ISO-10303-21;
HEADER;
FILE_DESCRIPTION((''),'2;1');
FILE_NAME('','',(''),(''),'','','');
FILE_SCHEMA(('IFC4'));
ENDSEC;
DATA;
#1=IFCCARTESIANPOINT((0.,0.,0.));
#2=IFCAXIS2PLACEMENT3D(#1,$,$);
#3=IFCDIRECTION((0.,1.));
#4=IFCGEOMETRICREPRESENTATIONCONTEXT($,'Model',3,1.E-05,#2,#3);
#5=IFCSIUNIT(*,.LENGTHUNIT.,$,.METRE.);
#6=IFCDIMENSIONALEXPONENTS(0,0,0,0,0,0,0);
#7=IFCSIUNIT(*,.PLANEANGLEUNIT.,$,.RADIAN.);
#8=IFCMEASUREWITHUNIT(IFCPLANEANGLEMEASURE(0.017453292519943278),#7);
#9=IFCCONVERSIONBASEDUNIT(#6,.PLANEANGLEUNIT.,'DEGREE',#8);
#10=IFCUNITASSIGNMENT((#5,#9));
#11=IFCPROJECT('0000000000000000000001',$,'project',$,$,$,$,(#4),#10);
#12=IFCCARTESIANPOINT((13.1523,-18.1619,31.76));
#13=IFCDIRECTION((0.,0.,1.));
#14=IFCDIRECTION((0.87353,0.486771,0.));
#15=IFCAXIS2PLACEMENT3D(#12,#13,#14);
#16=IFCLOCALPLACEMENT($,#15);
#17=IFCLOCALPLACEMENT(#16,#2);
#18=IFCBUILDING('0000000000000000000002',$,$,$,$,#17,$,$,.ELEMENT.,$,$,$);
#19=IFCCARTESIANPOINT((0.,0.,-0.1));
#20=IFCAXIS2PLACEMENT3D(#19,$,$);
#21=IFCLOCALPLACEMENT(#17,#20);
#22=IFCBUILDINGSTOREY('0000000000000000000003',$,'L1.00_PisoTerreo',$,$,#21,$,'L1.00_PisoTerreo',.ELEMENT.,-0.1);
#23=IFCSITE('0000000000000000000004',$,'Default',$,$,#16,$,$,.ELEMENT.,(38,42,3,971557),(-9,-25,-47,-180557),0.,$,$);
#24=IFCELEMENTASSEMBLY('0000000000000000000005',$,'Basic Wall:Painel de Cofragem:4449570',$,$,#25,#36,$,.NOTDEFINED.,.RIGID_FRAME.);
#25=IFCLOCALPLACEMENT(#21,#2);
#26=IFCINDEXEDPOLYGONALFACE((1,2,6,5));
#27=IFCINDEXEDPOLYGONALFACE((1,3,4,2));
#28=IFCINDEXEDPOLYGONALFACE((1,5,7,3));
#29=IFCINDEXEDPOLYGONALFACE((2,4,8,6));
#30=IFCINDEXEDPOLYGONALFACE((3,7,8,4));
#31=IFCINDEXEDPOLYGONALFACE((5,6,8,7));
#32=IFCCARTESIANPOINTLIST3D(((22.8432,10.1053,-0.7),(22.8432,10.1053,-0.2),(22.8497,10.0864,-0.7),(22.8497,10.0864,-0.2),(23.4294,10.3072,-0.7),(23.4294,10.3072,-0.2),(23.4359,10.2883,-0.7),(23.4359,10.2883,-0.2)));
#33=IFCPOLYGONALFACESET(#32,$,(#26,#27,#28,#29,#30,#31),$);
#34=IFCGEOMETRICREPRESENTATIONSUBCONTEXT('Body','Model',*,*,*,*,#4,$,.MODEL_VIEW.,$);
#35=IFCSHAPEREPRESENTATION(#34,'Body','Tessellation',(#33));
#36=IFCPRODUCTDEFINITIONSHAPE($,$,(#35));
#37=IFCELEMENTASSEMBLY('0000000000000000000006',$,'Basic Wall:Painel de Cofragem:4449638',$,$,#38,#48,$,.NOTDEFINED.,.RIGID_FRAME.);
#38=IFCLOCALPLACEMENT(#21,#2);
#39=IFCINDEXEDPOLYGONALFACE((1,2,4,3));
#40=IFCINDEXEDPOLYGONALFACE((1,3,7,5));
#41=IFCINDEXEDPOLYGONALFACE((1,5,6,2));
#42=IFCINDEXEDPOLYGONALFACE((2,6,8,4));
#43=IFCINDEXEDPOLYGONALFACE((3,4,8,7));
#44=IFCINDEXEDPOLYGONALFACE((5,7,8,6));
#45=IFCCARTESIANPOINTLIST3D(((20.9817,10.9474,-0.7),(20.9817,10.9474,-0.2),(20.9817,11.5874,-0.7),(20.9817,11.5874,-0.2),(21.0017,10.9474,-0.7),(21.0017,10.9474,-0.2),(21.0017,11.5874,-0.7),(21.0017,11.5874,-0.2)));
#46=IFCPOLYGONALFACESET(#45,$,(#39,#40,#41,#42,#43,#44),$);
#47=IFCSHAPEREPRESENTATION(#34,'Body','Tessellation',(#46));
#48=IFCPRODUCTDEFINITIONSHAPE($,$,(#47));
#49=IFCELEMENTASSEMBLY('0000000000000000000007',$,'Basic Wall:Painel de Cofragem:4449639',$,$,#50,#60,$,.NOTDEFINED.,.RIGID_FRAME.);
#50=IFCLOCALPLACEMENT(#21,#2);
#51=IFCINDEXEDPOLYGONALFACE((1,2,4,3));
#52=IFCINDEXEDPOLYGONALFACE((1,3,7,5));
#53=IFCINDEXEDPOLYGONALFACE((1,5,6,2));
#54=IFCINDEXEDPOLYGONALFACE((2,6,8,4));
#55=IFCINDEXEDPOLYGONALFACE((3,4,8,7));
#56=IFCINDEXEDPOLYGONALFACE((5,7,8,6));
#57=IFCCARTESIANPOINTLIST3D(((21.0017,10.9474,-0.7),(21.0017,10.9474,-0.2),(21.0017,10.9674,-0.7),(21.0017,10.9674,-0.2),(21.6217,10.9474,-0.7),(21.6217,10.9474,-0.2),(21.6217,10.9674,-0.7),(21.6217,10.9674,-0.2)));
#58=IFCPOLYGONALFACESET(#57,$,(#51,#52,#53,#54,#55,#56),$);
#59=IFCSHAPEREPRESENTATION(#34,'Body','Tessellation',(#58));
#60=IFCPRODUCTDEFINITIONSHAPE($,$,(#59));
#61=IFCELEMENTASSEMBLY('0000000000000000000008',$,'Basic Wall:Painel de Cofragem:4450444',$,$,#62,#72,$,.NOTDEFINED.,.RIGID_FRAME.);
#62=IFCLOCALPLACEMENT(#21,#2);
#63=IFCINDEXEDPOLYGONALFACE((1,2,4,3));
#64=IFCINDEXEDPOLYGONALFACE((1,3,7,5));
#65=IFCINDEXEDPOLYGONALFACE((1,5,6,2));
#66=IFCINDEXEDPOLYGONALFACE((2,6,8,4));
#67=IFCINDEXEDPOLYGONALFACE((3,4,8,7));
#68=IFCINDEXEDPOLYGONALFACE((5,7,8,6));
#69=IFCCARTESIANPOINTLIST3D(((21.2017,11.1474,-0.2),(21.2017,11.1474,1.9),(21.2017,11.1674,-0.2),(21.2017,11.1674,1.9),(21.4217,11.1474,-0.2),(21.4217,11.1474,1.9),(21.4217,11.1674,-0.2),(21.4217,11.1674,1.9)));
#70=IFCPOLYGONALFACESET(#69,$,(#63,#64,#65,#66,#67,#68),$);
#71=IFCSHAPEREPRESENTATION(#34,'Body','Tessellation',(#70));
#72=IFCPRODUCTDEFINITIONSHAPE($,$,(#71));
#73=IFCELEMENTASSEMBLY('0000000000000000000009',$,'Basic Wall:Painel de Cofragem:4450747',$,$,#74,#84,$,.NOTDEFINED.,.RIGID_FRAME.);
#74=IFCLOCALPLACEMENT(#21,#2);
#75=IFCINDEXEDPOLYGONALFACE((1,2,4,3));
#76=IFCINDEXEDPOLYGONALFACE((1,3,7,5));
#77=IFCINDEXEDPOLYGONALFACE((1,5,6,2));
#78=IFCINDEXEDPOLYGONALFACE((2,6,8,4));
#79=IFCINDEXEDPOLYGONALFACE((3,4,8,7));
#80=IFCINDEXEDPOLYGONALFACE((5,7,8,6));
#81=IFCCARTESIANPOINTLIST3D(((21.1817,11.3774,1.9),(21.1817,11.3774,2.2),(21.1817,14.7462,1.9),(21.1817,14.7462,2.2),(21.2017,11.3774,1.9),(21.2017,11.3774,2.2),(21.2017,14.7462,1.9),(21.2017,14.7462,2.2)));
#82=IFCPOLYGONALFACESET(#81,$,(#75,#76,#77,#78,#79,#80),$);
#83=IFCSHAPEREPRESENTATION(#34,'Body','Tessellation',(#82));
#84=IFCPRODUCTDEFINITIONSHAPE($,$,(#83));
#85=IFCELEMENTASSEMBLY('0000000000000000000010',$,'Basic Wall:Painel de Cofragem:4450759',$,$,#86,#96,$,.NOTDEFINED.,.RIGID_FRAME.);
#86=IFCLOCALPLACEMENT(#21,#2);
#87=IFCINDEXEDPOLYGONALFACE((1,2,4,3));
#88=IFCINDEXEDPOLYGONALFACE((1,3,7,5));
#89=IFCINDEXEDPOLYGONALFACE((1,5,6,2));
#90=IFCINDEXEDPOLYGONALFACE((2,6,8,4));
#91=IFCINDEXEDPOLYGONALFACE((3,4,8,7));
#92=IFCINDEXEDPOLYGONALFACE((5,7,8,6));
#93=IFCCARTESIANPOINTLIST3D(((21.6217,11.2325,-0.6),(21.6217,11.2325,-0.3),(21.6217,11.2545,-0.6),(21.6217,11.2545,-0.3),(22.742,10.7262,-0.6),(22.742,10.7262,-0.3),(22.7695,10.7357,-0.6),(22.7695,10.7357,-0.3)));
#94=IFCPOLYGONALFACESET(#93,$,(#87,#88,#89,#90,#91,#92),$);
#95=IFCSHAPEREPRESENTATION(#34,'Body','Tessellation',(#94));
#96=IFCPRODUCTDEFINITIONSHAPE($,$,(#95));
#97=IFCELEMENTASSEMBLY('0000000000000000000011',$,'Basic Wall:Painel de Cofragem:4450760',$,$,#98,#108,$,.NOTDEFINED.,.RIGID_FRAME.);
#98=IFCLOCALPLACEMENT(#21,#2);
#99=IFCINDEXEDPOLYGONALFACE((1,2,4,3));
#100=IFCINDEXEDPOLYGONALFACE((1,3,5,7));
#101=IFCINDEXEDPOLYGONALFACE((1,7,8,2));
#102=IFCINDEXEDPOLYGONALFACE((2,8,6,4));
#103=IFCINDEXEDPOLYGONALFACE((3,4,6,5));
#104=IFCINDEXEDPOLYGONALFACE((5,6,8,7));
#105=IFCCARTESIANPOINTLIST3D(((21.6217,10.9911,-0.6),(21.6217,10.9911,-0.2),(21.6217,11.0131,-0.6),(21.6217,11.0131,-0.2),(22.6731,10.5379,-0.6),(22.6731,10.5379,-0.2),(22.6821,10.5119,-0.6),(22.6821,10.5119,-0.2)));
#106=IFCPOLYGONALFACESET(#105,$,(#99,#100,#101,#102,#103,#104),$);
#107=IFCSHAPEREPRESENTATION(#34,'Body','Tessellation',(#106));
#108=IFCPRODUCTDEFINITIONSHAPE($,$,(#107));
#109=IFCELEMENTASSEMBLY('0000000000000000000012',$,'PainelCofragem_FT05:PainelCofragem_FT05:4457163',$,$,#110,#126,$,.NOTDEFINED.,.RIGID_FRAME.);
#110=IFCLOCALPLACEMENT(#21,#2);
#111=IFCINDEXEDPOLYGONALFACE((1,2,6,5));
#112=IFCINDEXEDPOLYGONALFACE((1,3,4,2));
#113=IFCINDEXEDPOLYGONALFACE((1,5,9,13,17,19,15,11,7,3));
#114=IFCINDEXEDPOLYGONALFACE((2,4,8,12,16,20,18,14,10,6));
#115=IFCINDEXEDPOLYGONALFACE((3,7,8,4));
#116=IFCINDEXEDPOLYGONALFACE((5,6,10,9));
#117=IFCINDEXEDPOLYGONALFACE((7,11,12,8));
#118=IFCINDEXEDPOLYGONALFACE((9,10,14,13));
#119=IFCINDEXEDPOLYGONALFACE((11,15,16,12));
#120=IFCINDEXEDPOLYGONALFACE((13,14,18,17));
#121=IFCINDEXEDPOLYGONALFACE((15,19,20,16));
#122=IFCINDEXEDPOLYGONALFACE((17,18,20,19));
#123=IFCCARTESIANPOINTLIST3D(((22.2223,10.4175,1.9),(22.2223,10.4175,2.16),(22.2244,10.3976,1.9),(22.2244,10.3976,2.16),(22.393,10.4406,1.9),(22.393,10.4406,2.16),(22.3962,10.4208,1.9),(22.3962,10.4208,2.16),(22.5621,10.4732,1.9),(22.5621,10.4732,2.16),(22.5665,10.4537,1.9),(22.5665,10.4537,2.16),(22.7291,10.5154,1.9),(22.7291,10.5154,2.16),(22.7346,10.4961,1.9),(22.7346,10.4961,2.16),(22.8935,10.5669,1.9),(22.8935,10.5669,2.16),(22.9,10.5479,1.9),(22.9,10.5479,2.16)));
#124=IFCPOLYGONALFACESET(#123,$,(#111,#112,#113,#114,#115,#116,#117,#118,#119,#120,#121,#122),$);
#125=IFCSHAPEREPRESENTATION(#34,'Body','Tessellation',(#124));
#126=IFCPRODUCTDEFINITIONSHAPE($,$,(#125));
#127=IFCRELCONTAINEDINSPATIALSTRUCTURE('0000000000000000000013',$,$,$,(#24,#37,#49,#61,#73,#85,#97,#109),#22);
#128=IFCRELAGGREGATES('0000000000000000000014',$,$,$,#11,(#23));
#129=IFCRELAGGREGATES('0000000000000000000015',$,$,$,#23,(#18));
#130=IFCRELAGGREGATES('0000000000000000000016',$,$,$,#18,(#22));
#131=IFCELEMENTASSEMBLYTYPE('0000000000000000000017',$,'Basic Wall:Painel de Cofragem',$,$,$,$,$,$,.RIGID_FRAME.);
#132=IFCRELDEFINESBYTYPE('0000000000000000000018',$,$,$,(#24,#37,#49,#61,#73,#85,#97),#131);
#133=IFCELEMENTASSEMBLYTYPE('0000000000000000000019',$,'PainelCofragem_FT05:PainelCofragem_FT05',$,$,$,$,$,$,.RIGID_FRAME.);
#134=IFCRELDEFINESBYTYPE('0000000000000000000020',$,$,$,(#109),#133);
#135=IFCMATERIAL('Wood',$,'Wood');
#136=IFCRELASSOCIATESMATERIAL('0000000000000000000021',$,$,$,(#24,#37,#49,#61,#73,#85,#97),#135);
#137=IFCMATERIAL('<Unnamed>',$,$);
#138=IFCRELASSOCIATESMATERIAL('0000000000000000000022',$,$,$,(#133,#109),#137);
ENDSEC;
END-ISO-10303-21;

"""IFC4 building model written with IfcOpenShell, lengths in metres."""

from ifc_helpers import new_model, entity, si_unit, converted_unit, direction, frame, origin, place, context, subcontext, project, spatial, line, arc, indexed_curve, outline, extrude, source, transform, mapped, material, type_object, type_shapes, element, save


model = new_model("IFC4")

# Units and contexts
model_context = context("Model", 3, precision=1e-05, world=origin(), true_north=direction((0.0, 1.0)))
body_context = subcontext(model_context, "Body", "Model", "MODEL_VIEW")
ifc_project = project(units=[si_unit("LENGTHUNIT", "METRE"), converted_unit("PLANEANGLEUNIT", "DEGREE", entity("IfcPlaneAngleMeasure", 0.017453292519943278), si_unit("PLANEANGLEUNIT", "RADIAN"), dimensions=[0, 0, 0, 0, 0, 0, 0])], contexts=[model_context])

# Site, building, storey
site_placement = place(None, frame((13.1523, -18.1619, 31.76), z_axis=(0.0, 0.0, 1.0), x_axis=(0.87353, 0.486771, 0.0)))
site = spatial("IfcSite", under=ifc_project, at=site_placement, Name="Default", CompositionType="ELEMENT", RefLatitude=(38, 42, 3, 971557), RefLongitude=(-9, -25, -47, -180557), RefElevation=0.0)
building_placement = place(site_placement, origin())
building = spatial("IfcBuilding", under=site, at=building_placement, CompositionType="ELEMENT")
storey_placement = place(building_placement, frame((0.0, 0.0, -0.1)))
storey = spatial("IfcBuildingStorey", under=building, at=storey_placement, Name="L1.00_PisoTerreo", LongName="L1.00_PisoTerreo", CompositionType="ELEMENT", Elevation=-0.1)

# Shared definitions
ifc_material_1 = material(Name="Wood", Category="Wood")

# Element assemblies
element_assembly_type_1 = type_object("IfcElementAssemblyType", Name="Basic Wall:Painel de Cofragem", PredefinedType="RIGID_FRAME")
assembly_1_placement = place(storey_placement, frame((22.8465, 10.0959, -0.7), z_axis=(0.0, 0.0, 1.0), x_axis=(0.945519, 0.325568, 0.0)))
element("IfcElementAssembly", 1, at=assembly_1_placement, inside=storey, type_object=element_assembly_type_1, material=ifc_material_1, Name="Basic Wall:Painel de Cofragem:4449570", AssemblyPlace="NOTDEFINED", PredefinedType="RIGID_FRAME", context=body_context, shape_type="SweptSolid", body=[
    extrude(outline(indexed_curve([(0.62, 0.01), (0.0, 0.01), (0.0, -0.01), (0.62, -0.01), (0.62, 0.01)], self_intersect=False)), origin(), (0.0, 0.0, 1.0), 0.5),
])
assembly_2_placement = place(storey_placement, frame((20.9917, 10.9474, -0.7), z_axis=(0.0, 0.0, 1.0), x_axis=(0.0, 1.0, 0.0)))
element("IfcElementAssembly", 2, at=assembly_2_placement, inside=storey, type_object=element_assembly_type_1, material=ifc_material_1, Name="Basic Wall:Painel de Cofragem:4449638", AssemblyPlace="NOTDEFINED", PredefinedType="RIGID_FRAME", context=body_context, shape_type="SweptSolid", body=[
    extrude(outline(indexed_curve([(0.64, 0.01), (0.0, 0.01), (0.0, -0.01), (0.64, -0.01), (0.64, 0.01)], self_intersect=False)), origin(), (0.0, 0.0, 1.0), 0.5),
])
assembly_3_placement = place(storey_placement, frame((21.0017, 10.9574, -0.7)))
element("IfcElementAssembly", 3, at=assembly_3_placement, inside=storey, type_object=element_assembly_type_1, material=ifc_material_1, Name="Basic Wall:Painel de Cofragem:4449639", AssemblyPlace="NOTDEFINED", PredefinedType="RIGID_FRAME", context=body_context, shape_type="SweptSolid", body=[
    extrude(outline(indexed_curve([(0.62, 0.01), (0.0, 0.01), (0.0, -0.01), (0.62, -0.01), (0.62, 0.01)], self_intersect=False)), origin(), (0.0, 0.0, 1.0), 0.5),
])
assembly_4_placement = place(storey_placement, frame((21.4217, 11.1574, -0.2), z_axis=(0.0, 0.0, 1.0), x_axis=(-1.0, 0.0, 0.0)))
element("IfcElementAssembly", 4, at=assembly_4_placement, inside=storey, type_object=element_assembly_type_1, material=ifc_material_1, Name="Basic Wall:Painel de Cofragem:4450444", AssemblyPlace="NOTDEFINED", PredefinedType="RIGID_FRAME", context=body_context, shape_type="SweptSolid", body=[
    extrude(outline(indexed_curve([(0.22, 0.01), (0.0, 0.01), (0.0, -0.01), (0.22, -0.01), (0.22, 0.01)], self_intersect=False)), origin(), (0.0, 0.0, 1.0), 2.1),
])
assembly_5_placement = place(storey_placement, frame((21.1917, 11.3774, 1.9), z_axis=(0.0, 0.0, 1.0), x_axis=(0.0, 1.0, 0.0)))
element("IfcElementAssembly", 5, at=assembly_5_placement, inside=storey, type_object=element_assembly_type_1, material=ifc_material_1, Name="Basic Wall:Painel de Cofragem:4450747", AssemblyPlace="NOTDEFINED", PredefinedType="RIGID_FRAME", context=body_context, shape_type="SweptSolid", body=[
    extrude(outline(indexed_curve([(3.3688, 0.01), (0.0, 0.01), (0.0, -0.01), (3.3688, -0.01), (3.3688, 0.01)], self_intersect=False)), origin(), (0.0, 0.0, 1.0), 0.3),
])
assembly_6_placement = place(storey_placement, frame((21.6176, 11.2454, -0.6), z_axis=(0.0, 0.0, 1.0), x_axis=(0.911251, -0.411852, 0.0)))
element("IfcElementAssembly", 6, at=assembly_6_placement, inside=storey, type_object=element_assembly_type_1, material=ifc_material_1, Name="Basic Wall:Painel de Cofragem:4450759", AssemblyPlace="NOTDEFINED", PredefinedType="RIGID_FRAME", context=body_context, shape_type="SweptSolid", body=[
    extrude(outline(indexed_curve([(1.2384, -0.01), (1.2596, 0.01), (0.0, 0.01), (0.009, -0.01), (1.2384, -0.01)], self_intersect=False)), origin(), (0.0, 0.0, 1.0), 0.3),
])
assembly_7_placement = place(storey_placement, frame((21.6176, 11.0039, -0.6), z_axis=(0.0, 0.0, 1.0), x_axis=(0.911251, -0.411852, 0.0)))
element("IfcElementAssembly", 7, at=assembly_7_placement, inside=storey, type_object=element_assembly_type_1, material=ifc_material_1, Name="Basic Wall:Painel de Cofragem:4450760", AssemblyPlace="NOTDEFINED", PredefinedType="RIGID_FRAME", context=body_context, shape_type="SweptSolid", body=[
    extrude(outline(indexed_curve([(1.1727, -0.01), (1.1538, 0.01), (0.0, 0.01), (0.009, -0.01), (1.1727, -0.01)], self_intersect=False)), origin(), (0.0, 0.0, 1.0), 0.4),
])
ifc_material_2 = material(Name="<Unnamed>")
element_assembly_type_2 = type_object("IfcElementAssemblyType", Name="PainelCofragem_FT05:PainelCofragem_FT05", PredefinedType="RIGID_FRAME", material=ifc_material_2)
shared_shape_1 = source(origin(), body_context, "Body", "SweptSolid", [
    extrude(outline(indexed_curve([(-0.0488, 0.3427), (-0.0293, -0.0033), (0.029, -0.345), (0.0485, -0.3405), (-0.0094, -0.0011), (-0.0288, 0.3427)], segments=[arc(1, 2, 3), line(3, 4), arc(4, 5, 6), line(6, 1)], self_intersect=False)), frame((0.3377, 0.0849, 0.0), z_axis=(0.0, 0.0, -1.0), x_axis=(-0.325568, 0.945519, 0.0)), (0.0, 0.0, -1.0), 0.26),
])
type_shapes(element_assembly_type_2, [shared_shape_1])
assembly_8_placement = place(storey_placement, frame((22.2223, 10.3976, 1.9)))
element("IfcElementAssembly", 8, at=assembly_8_placement, inside=storey, type_object=element_assembly_type_2, material=ifc_material_2, Name="PainelCofragem_FT05:PainelCofragem_FT05:4457163", AssemblyPlace="NOTDEFINED", PredefinedType="RIGID_FRAME", context=body_context, shape_type="MappedRepresentation", body=[
    mapped(shared_shape_1, transform((0.0, 0.0, 0.0), scale=1.0)),
])

save(model, "model.ifc")
